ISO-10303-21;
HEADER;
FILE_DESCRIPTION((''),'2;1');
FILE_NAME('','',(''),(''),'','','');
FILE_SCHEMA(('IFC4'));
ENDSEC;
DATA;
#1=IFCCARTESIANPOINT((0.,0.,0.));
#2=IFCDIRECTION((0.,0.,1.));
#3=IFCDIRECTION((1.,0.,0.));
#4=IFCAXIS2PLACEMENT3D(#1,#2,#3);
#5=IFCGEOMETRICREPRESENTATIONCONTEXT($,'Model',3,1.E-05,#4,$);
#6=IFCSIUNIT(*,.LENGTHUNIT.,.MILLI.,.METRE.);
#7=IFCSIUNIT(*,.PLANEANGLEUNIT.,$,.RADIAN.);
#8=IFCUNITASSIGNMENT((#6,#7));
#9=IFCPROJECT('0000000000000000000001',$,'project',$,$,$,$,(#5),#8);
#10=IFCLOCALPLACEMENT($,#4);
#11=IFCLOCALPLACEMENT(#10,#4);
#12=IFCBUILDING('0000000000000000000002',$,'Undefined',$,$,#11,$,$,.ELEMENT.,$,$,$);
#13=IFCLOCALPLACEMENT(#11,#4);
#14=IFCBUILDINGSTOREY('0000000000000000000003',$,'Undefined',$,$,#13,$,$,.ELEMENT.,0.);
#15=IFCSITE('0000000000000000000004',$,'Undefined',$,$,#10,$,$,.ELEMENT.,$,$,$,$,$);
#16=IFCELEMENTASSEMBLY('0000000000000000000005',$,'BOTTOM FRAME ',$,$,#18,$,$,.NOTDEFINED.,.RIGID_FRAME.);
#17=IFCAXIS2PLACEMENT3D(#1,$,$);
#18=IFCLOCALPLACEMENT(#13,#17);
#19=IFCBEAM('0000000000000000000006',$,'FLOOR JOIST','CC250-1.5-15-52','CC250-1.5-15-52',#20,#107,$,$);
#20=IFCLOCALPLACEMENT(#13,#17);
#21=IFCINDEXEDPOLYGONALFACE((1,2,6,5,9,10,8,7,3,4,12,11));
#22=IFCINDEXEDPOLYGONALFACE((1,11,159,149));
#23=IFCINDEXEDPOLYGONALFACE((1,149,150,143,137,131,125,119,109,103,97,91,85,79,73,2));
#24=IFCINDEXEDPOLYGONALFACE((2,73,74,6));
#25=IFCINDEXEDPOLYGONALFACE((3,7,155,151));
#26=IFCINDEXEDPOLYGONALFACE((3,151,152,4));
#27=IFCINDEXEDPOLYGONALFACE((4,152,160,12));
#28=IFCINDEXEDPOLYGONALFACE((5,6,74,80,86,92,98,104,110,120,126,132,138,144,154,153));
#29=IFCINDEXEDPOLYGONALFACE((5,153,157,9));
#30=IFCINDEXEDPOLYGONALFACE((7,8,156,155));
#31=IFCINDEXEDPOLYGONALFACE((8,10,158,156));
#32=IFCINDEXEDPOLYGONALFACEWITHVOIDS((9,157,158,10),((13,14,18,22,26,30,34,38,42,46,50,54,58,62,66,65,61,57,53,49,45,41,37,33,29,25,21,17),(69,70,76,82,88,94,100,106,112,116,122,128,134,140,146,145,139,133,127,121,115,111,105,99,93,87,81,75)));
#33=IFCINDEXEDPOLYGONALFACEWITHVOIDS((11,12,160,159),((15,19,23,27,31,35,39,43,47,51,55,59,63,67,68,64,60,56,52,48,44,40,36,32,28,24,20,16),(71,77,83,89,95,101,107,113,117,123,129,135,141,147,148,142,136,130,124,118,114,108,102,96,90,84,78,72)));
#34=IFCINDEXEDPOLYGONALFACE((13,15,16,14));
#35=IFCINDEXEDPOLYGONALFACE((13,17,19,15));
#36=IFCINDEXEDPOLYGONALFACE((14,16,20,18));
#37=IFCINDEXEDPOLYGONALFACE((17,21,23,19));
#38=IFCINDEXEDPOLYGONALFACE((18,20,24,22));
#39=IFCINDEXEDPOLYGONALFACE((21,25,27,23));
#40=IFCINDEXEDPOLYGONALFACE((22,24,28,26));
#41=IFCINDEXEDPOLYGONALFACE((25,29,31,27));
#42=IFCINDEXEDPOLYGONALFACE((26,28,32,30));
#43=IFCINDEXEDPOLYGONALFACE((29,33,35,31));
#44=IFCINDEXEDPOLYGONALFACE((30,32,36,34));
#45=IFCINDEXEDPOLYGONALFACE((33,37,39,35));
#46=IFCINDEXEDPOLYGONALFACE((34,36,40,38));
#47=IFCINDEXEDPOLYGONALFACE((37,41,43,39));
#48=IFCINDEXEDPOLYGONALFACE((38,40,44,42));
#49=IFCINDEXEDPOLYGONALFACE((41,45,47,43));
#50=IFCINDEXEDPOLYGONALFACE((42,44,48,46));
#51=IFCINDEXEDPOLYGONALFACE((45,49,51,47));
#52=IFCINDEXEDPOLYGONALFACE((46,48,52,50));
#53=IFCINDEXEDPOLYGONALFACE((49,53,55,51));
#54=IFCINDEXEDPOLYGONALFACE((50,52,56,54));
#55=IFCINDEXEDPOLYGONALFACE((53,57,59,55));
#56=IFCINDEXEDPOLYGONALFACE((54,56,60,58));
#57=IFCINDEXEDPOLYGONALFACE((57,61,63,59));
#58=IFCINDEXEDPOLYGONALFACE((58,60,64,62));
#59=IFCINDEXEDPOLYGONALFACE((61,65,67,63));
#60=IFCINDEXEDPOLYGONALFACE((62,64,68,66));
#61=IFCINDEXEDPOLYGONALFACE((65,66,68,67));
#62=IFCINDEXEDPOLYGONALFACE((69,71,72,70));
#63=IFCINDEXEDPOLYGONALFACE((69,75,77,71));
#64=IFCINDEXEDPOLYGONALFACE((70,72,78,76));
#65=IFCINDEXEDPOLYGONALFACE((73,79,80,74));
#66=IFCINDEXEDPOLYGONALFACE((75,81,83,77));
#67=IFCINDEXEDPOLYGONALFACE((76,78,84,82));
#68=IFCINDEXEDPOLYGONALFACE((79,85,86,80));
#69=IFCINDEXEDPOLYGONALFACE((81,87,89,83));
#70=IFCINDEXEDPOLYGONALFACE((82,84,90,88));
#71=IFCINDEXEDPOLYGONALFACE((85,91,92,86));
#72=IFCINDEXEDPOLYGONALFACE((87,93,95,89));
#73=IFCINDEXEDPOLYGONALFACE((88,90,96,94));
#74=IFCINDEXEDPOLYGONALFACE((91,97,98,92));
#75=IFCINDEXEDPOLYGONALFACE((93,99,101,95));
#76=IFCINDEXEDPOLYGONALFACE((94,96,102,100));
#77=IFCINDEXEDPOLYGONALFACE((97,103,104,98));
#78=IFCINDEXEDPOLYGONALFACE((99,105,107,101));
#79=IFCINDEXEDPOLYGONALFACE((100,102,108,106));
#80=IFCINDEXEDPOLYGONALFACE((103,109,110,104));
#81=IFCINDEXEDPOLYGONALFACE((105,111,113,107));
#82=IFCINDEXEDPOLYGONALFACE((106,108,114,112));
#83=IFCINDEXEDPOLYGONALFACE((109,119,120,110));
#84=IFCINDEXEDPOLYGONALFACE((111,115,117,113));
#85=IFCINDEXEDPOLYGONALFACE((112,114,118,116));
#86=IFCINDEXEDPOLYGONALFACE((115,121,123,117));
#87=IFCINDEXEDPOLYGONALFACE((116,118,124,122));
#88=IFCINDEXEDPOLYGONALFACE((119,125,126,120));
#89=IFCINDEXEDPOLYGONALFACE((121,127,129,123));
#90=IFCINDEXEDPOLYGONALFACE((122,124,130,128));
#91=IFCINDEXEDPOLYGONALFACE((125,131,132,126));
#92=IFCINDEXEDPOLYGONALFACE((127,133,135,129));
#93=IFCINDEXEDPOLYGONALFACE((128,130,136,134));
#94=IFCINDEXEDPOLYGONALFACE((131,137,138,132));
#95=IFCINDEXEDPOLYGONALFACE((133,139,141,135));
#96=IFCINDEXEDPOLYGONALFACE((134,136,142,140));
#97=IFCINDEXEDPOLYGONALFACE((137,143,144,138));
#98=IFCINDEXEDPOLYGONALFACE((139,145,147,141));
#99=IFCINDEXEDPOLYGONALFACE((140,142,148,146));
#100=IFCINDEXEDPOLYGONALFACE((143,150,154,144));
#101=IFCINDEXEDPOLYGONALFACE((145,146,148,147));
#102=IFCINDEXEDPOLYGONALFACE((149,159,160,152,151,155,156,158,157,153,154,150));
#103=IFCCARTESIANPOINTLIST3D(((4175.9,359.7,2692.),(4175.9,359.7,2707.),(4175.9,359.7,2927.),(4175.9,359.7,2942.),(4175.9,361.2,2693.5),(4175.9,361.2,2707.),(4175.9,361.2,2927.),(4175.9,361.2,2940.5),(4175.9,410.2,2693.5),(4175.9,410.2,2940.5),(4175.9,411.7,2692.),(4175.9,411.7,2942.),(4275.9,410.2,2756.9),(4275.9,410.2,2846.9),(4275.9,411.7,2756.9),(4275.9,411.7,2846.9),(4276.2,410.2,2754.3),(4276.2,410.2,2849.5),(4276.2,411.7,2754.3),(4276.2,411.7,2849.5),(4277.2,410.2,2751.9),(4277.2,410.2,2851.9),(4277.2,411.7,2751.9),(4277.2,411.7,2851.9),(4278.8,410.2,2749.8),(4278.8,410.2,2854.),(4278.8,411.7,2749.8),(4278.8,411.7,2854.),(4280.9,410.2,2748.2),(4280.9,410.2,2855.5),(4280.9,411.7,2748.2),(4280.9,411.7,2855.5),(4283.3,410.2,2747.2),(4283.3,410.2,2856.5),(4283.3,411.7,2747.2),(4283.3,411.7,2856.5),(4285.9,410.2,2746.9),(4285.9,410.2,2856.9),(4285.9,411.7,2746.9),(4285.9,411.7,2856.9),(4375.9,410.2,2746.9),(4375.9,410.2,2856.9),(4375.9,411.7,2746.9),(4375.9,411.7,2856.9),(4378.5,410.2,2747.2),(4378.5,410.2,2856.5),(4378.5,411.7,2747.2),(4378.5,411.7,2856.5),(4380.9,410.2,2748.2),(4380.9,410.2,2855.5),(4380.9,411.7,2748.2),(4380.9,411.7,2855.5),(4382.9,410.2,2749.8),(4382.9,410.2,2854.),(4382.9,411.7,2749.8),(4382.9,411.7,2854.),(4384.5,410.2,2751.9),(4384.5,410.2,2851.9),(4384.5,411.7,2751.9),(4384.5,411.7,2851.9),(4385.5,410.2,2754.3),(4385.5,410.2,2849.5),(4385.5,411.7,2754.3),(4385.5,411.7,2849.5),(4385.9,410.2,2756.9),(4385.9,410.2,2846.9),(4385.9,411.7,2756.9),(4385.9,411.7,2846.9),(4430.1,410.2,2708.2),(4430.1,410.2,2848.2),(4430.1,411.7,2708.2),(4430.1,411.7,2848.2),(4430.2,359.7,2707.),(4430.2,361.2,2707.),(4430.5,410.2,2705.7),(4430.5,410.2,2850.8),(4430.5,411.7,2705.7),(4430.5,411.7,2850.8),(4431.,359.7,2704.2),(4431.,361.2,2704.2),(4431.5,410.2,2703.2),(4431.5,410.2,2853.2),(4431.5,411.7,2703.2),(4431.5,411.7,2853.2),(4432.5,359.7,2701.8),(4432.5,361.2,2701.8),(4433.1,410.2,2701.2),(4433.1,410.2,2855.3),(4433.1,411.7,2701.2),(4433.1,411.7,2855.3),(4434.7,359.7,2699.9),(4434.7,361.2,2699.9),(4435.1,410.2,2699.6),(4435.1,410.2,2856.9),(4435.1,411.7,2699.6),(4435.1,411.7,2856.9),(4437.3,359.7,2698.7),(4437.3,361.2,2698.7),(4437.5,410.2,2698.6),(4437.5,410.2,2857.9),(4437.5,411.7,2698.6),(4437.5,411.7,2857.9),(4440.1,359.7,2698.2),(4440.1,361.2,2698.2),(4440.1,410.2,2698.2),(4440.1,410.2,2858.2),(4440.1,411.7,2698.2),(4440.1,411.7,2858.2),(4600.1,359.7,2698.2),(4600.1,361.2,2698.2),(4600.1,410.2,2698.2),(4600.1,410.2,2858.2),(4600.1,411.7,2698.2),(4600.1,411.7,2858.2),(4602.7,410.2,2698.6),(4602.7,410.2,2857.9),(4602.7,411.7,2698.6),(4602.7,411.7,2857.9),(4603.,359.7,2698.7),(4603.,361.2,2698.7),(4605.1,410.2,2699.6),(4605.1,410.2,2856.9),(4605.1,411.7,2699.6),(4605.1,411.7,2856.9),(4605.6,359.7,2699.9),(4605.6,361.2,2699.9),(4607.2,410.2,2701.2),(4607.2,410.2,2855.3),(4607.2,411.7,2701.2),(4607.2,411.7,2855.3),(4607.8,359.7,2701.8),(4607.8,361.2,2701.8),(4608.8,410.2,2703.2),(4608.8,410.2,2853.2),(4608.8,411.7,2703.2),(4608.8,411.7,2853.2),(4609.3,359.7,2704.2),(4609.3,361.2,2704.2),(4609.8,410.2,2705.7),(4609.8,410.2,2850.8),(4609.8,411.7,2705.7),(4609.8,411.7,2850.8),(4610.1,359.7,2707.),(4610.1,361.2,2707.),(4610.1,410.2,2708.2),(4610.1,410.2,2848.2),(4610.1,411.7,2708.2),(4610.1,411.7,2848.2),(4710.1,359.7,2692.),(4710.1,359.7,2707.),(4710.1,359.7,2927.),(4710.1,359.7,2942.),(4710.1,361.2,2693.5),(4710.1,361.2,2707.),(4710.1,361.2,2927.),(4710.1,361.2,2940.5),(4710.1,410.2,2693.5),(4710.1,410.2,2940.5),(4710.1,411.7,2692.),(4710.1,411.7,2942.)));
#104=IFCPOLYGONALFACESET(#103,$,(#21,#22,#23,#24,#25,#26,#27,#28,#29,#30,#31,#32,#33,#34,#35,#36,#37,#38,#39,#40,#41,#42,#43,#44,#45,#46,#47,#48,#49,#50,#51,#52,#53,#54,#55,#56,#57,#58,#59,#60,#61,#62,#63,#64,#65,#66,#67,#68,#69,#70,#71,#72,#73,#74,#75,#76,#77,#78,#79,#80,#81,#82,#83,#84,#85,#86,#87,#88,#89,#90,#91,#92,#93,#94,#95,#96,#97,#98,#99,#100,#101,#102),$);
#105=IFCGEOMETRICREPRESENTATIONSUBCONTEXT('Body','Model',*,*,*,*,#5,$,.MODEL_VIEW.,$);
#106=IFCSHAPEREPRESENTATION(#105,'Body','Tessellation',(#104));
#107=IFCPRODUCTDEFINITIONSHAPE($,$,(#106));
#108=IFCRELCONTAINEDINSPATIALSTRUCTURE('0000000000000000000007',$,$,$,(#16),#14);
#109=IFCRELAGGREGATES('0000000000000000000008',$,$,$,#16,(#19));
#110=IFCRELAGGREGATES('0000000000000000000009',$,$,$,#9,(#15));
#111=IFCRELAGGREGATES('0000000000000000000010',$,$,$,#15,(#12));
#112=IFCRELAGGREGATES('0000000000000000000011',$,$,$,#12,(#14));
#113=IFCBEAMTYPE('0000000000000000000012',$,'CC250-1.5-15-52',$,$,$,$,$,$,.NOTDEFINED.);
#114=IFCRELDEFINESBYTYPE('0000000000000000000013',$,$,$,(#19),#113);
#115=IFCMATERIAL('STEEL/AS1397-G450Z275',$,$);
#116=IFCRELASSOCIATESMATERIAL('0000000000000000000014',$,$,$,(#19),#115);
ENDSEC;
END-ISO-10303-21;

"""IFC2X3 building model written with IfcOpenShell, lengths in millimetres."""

from ifc_helpers import new_model, si_unit, frame, frame_2d, origin_with_axes, origin_2d_with_axis, place, context, subcontext, project, spatial, polyline, circle_curve, parameter, trimmed, segment, composite_curve, c_section, outline, extrude, boolean, material, type_object, element, aggregate, save


model = new_model("IFC2X3")

# Units and contexts
model_context = context("Model", 3, precision=1e-05, world=origin_with_axes())
body_context = subcontext(model_context, "Body", "Model", "MODEL_VIEW")
ifc_project = project(units=[si_unit("LENGTHUNIT", "METRE", prefix="MILLI"), si_unit("PLANEANGLEUNIT", "RADIAN")], contexts=[model_context])

# Site, building, storey
site_placement = place(None, origin_with_axes())
site = spatial("IfcSite", under=ifc_project, at=site_placement, Name="Undefined", CompositionType="ELEMENT")
building_placement = place(site_placement, origin_with_axes())
building = spatial("IfcBuilding", under=site, at=building_placement, Name="Undefined", CompositionType="ELEMENT")
storey_placement = place(building_placement, origin_with_axes())
storey = spatial("IfcBuildingStorey", under=building, at=storey_placement, Name="Undefined", CompositionType="ELEMENT", Elevation=0.0)

# Element assembly, beam
assembly_1_placement = place(storey_placement, origin_with_axes())
assembly_1 = element("IfcElementAssembly", 1, at=assembly_1_placement, inside=storey, Name="BOTTOM FRAME ", AssemblyPlace="NOTDEFINED", PredefinedType="RIGID_FRAME")
ifc_material_1 = material(Name="STEEL/AS1397-G450Z275")
beam_type_1 = type_object("IfcBeamType", Name="CC250-1.5-15-52", PredefinedType="NOTDEFINED")
beam_1_placement = place(assembly_1_placement, frame((4710.1, 385.7, 2817.0), z_axis=(0.0, 0.0, -1.0), x_axis=(-1.0, 0.0, 0.0)))
beam_1 = element("IfcBeam", 2, at=beam_1_placement, type_object=beam_type_1, material=ifc_material_1, Name="FLOOR JOIST", Description="CC250-1.5-15-52", ObjectType="CC250-1.5-15-52", context=body_context, shape_type="CSG", body=[
    boolean("DIFFERENCE", boolean("DIFFERENCE", extrude(c_section(Depth=250.0, Width=52.0, WallThickness=1.5, Girth=15.0, at=origin_2d_with_axis()), frame((534.3, 0.0, 0.0), z_axis=(-1.0, 0.0, 0.0), x_axis=(0.0, -1.0, 0.0)), (0.0, 0.0, 1.0), 534.3), extrude(outline(composite_curve([segment(trimmed(circle_curve(frame_2d((10.0, 10.0), x_axis=(-1.0, 0.0)), 10.0), [parameter(0.0)], [parameter(1.570796)], True, "PARAMETER"), True, "CONTINUOUS"), segment(polyline([(10.0, 0.0), (170.0, 0.0)]), True, "CONTINUOUS"), segment(trimmed(circle_curve(frame_2d((170.0, 10.0), x_axis=(0.0, -1.0)), 10.0), [parameter(0.0)], [parameter(1.570796)], True, "PARAMETER"), True, "CONTINUOUS"), segment(polyline([(180.0, 10.0), (180.0, 150.0)]), True, "CONTINUOUS"), segment(trimmed(circle_curve(frame_2d((170.0, 150.0), x_axis=(1.0, 0.0)), 10.0), [parameter(0.0)], [parameter(1.570796)], True, "PARAMETER"), True, "CONTINUOUS"), segment(polyline([(170.0, 160.0), (10.0, 160.0)]), True, "CONTINUOUS"), segment(trimmed(circle_curve(frame_2d((10.0, 150.0), x_axis=(0.0, 1.0)), 10.0), [parameter(0.0)], [parameter(1.570796)], True, "PARAMETER"), True, "CONTINUOUS"), segment(polyline([(0.0, 150.0), (0.0, 10.0)]), True, "CONTINUOUS")], self_intersect=True)), frame((280.0, -40.5, -41.2), z_axis=(0.0, 1.0, 0.0), x_axis=(-1.0, 0.0, 0.0)), (0.0, 0.0, 1.0), 81.0)), extrude(outline(composite_curve([segment(trimmed(circle_curve(frame_2d((10.0, 10.0), x_axis=(-1.0, 0.0)), 10.0), [parameter(0.0)], [parameter(1.570796)], True, "PARAMETER"), True, "CONTINUOUS"), segment(polyline([(10.0, 0.0), (100.0, 0.0)]), True, "CONTINUOUS"), segment(trimmed(circle_curve(frame_2d((100.0, 10.0), x_axis=(0.0, -1.0)), 10.0), [parameter(0.0)], [parameter(1.570796)], True, "PARAMETER"), True, "CONTINUOUS"), segment(polyline([(110.0, 10.0), (110.0, 100.0)]), True, "CONTINUOUS"), segment(trimmed(circle_curve(frame_2d((100.0, 100.0), x_axis=(1.0, 0.0)), 10.0), [parameter(0.0)], [parameter(1.570796)], True, "PARAMETER"), True, "CONTINUOUS"), segment(polyline([(100.0, 110.0), (10.0, 110.0)]), True, "CONTINUOUS"), segment(trimmed(circle_curve(frame_2d((10.0, 100.0), x_axis=(0.0, 1.0)), 10.0), [parameter(0.0)], [parameter(1.570796)], True, "PARAMETER"), True, "CONTINUOUS"), segment(polyline([(0.0, 100.0), (0.0, 10.0)]), True, "CONTINUOUS")], self_intersect=True)), frame((434.3, -40.5, -39.9), z_axis=(0.0, 1.0, 0.0), x_axis=(-1.0, 0.0, 0.0)), (0.0, 0.0, 1.0), 81.0)),
])

aggregate(assembly_1, [beam_1])

save(model, "model.ifc")
